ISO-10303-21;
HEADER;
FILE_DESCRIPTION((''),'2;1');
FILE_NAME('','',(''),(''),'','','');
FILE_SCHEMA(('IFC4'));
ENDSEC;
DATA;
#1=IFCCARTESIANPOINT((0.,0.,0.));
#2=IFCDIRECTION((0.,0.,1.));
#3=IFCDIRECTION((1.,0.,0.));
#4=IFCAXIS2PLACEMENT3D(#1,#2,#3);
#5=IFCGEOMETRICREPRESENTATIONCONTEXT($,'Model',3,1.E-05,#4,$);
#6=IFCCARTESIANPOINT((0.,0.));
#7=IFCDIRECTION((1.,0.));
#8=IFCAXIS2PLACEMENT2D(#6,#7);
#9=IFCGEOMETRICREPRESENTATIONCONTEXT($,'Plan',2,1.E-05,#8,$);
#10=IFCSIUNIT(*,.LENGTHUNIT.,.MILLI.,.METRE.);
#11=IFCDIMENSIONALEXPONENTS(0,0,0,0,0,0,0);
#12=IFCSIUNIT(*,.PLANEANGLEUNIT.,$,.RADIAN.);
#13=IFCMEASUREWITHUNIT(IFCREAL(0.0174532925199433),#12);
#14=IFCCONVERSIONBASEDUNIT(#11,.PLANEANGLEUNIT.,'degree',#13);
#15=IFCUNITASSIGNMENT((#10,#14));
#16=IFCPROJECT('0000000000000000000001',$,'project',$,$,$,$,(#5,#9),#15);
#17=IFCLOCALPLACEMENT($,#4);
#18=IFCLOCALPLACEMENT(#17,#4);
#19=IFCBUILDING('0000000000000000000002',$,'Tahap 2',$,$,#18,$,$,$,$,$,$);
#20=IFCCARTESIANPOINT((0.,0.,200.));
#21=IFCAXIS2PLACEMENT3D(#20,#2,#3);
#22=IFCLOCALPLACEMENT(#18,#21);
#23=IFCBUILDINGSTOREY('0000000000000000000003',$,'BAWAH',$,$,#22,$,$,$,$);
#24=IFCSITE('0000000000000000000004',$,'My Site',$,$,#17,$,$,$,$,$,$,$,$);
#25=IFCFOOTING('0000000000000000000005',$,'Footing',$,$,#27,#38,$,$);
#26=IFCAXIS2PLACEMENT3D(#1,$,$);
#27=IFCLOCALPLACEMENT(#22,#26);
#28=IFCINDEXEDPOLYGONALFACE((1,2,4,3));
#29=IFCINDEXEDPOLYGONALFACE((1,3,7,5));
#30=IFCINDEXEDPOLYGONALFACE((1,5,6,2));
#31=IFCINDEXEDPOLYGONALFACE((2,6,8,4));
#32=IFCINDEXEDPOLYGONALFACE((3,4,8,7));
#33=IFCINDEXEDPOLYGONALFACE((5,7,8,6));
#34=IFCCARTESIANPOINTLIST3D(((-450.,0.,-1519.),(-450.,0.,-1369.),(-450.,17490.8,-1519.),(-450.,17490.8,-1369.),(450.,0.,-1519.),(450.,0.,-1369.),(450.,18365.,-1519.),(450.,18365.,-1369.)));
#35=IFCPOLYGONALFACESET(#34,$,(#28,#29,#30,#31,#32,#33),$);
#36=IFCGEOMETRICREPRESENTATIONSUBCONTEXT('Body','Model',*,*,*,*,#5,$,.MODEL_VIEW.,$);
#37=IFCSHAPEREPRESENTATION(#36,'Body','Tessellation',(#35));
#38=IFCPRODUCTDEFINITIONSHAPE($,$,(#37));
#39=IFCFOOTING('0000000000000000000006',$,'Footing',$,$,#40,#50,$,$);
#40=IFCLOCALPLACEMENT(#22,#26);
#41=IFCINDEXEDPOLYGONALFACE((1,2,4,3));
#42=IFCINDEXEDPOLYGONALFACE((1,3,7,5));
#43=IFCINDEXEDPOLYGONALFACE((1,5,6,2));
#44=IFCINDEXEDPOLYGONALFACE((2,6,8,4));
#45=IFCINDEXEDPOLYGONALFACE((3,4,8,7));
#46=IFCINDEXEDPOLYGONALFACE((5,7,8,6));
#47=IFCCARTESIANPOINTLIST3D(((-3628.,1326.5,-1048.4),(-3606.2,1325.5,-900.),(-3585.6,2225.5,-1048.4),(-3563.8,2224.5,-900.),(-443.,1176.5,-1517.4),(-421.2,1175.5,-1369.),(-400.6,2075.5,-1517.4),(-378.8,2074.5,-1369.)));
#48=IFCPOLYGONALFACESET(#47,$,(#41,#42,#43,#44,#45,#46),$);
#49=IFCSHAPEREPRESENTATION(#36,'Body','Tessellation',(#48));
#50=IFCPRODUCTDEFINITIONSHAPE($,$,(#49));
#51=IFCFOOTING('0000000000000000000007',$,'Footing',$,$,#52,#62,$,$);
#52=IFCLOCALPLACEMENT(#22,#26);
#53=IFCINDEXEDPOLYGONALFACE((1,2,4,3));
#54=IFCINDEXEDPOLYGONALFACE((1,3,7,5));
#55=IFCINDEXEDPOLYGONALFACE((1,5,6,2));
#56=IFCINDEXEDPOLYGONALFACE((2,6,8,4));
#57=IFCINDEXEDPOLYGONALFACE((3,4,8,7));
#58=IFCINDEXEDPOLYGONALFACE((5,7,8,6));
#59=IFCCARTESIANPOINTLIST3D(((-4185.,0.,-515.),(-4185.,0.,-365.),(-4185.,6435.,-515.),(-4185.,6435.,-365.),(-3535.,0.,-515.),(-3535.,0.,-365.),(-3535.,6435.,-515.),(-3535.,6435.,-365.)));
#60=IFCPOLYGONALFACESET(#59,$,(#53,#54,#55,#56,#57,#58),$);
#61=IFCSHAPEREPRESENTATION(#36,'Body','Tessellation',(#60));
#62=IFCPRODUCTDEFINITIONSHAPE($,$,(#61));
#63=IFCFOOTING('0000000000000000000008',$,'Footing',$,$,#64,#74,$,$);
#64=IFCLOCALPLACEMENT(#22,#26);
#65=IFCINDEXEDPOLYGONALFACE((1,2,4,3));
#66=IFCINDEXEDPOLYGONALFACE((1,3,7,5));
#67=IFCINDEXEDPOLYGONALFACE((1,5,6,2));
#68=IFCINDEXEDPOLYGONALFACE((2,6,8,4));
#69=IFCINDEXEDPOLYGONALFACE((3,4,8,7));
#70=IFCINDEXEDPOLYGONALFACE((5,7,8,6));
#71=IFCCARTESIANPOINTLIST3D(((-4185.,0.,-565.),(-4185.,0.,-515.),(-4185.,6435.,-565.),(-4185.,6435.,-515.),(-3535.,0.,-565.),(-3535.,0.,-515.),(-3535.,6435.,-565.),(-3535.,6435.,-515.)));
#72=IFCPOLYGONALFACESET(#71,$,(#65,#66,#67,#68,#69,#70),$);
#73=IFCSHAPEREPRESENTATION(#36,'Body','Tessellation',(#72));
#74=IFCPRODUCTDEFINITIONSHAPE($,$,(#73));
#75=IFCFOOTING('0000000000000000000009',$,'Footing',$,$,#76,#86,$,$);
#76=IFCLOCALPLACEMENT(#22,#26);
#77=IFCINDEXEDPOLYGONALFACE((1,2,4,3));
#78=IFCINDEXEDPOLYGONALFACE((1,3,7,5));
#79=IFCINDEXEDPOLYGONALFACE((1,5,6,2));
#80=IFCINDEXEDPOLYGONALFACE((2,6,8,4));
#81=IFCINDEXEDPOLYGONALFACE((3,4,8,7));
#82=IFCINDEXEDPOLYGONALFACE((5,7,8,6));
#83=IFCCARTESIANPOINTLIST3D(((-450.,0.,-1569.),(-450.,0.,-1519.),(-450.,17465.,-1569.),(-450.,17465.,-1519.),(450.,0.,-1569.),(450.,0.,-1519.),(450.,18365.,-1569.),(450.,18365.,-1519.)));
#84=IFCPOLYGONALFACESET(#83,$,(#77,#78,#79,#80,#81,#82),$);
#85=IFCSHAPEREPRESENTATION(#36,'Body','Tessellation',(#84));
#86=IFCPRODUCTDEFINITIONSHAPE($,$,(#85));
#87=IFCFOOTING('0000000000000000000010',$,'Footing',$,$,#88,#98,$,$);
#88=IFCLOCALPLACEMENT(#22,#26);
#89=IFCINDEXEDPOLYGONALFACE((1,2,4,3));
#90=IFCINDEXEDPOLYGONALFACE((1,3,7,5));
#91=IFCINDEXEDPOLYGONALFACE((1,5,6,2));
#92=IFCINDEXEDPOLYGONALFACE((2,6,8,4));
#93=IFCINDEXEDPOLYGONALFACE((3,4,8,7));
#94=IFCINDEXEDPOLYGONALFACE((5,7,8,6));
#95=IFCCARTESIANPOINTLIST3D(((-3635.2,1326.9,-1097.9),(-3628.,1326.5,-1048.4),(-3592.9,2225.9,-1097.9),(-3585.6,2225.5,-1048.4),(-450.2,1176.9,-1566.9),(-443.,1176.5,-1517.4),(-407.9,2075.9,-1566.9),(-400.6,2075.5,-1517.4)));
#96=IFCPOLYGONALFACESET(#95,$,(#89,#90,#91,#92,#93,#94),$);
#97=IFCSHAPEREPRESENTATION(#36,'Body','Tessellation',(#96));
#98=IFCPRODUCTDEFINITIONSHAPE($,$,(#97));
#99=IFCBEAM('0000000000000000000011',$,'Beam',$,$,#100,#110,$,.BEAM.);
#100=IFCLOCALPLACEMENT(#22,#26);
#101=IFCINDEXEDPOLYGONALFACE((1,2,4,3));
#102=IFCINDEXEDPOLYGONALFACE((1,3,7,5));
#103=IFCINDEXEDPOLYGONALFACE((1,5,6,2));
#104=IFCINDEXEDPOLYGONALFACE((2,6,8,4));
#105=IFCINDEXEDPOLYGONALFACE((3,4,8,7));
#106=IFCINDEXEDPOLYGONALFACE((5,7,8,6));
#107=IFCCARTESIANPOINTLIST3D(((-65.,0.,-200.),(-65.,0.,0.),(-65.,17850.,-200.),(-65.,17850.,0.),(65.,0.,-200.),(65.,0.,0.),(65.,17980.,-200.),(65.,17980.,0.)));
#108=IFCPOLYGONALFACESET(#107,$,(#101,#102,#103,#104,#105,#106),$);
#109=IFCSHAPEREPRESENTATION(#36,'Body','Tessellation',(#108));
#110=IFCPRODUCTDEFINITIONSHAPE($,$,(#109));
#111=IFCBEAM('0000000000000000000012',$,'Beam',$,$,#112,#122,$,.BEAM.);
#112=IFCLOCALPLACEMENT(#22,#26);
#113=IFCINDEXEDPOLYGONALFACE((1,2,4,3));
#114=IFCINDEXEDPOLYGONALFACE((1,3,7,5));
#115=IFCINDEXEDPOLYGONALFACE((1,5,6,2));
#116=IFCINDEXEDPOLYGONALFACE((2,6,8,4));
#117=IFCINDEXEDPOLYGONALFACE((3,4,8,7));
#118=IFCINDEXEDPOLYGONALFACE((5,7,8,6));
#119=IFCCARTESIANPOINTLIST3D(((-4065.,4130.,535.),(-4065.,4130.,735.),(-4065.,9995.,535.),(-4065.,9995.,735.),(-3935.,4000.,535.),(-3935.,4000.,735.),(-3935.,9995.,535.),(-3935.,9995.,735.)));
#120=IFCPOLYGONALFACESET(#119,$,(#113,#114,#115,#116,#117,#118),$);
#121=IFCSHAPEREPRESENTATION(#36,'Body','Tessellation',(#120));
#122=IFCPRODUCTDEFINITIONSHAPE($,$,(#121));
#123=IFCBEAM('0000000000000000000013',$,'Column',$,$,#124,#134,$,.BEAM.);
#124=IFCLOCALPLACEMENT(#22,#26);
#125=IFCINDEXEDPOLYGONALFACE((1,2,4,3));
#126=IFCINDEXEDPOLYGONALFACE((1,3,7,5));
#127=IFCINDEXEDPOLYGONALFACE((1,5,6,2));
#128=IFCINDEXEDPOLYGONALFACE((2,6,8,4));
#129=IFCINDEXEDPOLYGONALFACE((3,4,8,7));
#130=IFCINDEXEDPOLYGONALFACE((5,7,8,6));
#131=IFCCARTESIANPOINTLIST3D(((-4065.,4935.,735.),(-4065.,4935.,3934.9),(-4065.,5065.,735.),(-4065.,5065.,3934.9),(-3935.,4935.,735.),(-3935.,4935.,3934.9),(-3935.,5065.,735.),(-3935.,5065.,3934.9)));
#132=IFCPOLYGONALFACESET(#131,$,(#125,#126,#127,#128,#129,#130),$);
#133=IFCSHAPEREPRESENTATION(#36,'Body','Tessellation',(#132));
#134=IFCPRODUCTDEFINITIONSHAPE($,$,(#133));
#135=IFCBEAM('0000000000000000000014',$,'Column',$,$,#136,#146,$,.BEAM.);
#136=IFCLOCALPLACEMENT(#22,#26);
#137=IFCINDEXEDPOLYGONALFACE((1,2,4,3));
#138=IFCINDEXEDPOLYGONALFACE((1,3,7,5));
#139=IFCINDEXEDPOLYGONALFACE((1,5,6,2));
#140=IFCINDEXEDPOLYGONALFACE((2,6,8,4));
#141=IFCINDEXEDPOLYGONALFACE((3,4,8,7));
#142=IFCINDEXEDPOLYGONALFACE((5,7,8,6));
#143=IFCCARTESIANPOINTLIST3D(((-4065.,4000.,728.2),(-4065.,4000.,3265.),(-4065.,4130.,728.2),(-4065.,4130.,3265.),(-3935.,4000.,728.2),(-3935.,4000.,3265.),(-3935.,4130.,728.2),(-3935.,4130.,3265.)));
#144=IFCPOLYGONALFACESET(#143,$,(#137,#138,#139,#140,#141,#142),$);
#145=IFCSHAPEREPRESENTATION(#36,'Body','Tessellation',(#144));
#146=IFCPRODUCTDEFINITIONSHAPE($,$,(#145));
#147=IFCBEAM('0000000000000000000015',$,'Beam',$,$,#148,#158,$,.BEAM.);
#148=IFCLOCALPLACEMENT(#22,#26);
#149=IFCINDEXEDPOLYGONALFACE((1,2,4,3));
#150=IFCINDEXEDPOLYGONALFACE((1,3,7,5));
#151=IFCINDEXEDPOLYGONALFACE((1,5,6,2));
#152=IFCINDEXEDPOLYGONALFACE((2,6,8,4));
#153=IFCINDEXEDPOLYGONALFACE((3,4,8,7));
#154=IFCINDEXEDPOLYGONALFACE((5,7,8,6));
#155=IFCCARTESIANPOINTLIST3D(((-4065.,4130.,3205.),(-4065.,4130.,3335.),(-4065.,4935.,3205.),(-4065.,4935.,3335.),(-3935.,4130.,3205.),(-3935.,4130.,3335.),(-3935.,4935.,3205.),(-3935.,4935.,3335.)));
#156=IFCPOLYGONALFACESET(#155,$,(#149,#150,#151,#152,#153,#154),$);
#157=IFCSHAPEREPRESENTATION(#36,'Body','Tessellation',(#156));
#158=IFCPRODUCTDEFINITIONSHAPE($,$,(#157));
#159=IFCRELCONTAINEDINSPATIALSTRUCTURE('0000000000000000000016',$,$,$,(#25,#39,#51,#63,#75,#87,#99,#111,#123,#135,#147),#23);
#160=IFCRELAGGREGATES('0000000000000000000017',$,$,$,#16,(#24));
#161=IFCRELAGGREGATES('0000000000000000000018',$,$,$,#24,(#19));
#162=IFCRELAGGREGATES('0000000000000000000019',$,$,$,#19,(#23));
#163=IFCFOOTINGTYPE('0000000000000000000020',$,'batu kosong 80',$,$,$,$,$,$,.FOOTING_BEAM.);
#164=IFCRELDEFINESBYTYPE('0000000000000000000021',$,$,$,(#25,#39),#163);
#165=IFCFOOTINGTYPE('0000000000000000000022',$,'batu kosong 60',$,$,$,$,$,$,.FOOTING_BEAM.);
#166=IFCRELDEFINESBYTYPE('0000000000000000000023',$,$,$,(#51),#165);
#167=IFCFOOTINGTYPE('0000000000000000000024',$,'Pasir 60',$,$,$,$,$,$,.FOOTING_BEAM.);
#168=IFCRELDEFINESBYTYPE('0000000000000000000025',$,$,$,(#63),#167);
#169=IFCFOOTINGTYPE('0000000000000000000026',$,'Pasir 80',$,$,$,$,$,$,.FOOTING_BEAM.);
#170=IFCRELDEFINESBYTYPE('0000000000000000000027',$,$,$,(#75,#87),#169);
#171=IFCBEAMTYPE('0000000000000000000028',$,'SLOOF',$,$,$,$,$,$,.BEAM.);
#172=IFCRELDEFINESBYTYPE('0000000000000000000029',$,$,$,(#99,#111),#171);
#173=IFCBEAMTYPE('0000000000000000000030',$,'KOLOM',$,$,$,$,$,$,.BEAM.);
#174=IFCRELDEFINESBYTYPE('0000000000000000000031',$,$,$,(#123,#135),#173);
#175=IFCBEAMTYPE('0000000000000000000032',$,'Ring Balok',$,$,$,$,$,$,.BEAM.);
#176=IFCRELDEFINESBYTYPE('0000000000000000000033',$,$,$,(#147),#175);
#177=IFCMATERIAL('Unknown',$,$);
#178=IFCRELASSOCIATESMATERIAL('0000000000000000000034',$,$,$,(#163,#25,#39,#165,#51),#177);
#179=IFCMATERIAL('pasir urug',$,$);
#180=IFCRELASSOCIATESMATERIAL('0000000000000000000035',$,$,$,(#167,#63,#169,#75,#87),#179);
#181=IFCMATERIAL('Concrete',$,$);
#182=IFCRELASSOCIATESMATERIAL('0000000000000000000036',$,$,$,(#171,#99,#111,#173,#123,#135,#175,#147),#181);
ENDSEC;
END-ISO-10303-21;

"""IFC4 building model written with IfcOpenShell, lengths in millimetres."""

from ifc_helpers import new_model, entity, si_unit, converted_unit, frame, origin_with_axes, origin_2d_with_axis, place, context, subcontext, project, spatial, indexed_curve, rectangle, outline, extrude, clip, halfspace, material, material_profile, profile_set, profile_usage, type_object, element, save


model = new_model("IFC4")

# Units and contexts
model_context = context("Model", 3, precision=1e-05, world=origin_with_axes())
plan_context = context("Plan", 2, precision=1e-05, world=origin_2d_with_axis())
body_context = subcontext(model_context, "Body", "Model", "MODEL_VIEW")
ifc_project = project(units=[si_unit("LENGTHUNIT", "METRE", prefix="MILLI"), converted_unit("PLANEANGLEUNIT", "degree", entity("IfcReal", 0.0174532925199433), si_unit("PLANEANGLEUNIT", "RADIAN"), dimensions=[0, 0, 0, 0, 0, 0, 0])], contexts=[model_context, plan_context])

# Site, building, storey
site_placement = place(None, origin_with_axes())
site = spatial("IfcSite", under=ifc_project, at=site_placement, Name="My Site")
building_placement = place(site_placement, origin_with_axes())
building = spatial("IfcBuilding", under=site, at=building_placement, Name="Tahap 2")
storey_placement = place(building_placement, frame((0.0, 0.0, 200.0), z_axis=(0.0, 0.0, 1.0), x_axis=(1.0, 0.0, 0.0)))
storey = spatial("IfcBuildingStorey", under=building, at=storey_placement, Name="BAWAH")

# Footings
ifc_material_1 = material(Name="Unknown")
ifc_material_profile_1 = material_profile(ifc_material_1, rectangle(XDim=900.0, YDim=150.0, kind="CURVE"))
ifc_profile_set_1 = profile_set([ifc_material_profile_1])
ifc_profile_usage_1 = profile_usage(ifc_profile_set_1, cardinal=8)
footing_type_1 = type_object("IfcFootingType", Name="batu kosong 80", PredefinedType="FOOTING_BEAM", material=ifc_profile_set_1)
footing_1_placement = place(storey_placement, frame((0.0, 0.0, -1369.0), z_axis=(0.0, 1.0, 0.0), x_axis=(-1.0, 0.0, 0.0)))
element("IfcFooting", 1, at=footing_1_placement, inside=storey, type_object=footing_type_1, material=ifc_profile_usage_1, Name="Footing", context=body_context, shape_type="Clipping", body=[
    clip(extrude(rectangle(XDim=900.0, YDim=150.0, kind="CURVE"), frame((0.0, -75.0, 0.0), z_axis=(0.0, 0.0, 1.0), x_axis=(1.0, 0.0, 0.0)), (0.0, 0.0, 1.0), 18365.0), halfspace(frame((-450.0, 1169.0, 18365.0), z_axis=(0.696756, 0.0, 0.717309), x_axis=(0.0, -1.0, 0.0)), False)),
])
ifc_profile_usage_2 = profile_usage(ifc_profile_set_1, cardinal=8)
footing_2_placement = place(storey_placement, frame((-400.0, 1625.0, -1369.0), z_axis=(-0.988259, 0.046543, 0.145524), x_axis=(-0.047044, -0.998893, 0.0)))
element("IfcFooting", 2, at=footing_2_placement, inside=storey, type_object=footing_type_1, material=ifc_profile_usage_2, Name="Footing", context=body_context, shape_type="SweptSolid", body=[
    extrude(rectangle(XDim=900.0, YDim=150.0, kind="CURVE"), frame((0.0, -75.0, 0.0), z_axis=(0.0, 0.0, 1.0), x_axis=(1.0, 0.0, 0.0)), (0.0, 0.0, 1.0), 3222.8),
])
ifc_material_profile_2 = material_profile(ifc_material_1, rectangle(XDim=650.0, YDim=150.0, kind="CURVE"))
ifc_profile_set_2 = profile_set([ifc_material_profile_2])
ifc_profile_usage_3 = profile_usage(ifc_profile_set_2, cardinal=9)
footing_type_2 = type_object("IfcFootingType", Name="batu kosong 60", PredefinedType="FOOTING_BEAM", material=ifc_profile_set_2)
footing_3_placement = place(storey_placement, frame((-3535.0, 0.0, -365.0), z_axis=(0.000001, 1.0, 0.0), x_axis=(-1.0, 0.000001, 0.0)))
element("IfcFooting", 3, at=footing_3_placement, inside=storey, type_object=footing_type_2, material=ifc_profile_usage_3, Name="Footing", context=body_context, shape_type="SweptSolid", body=[
    extrude(rectangle(XDim=650.0, YDim=150.0, kind="CURVE"), frame((325.0, -75.0, 0.0), z_axis=(0.0, 0.0, 1.0), x_axis=(1.0, 0.0, 0.0)), (0.0, 0.0, 1.0), 6435.0),
])
ifc_material_2 = material(Name="pasir urug")
ifc_material_profile_3 = material_profile(ifc_material_2, rectangle(XDim=650.0, YDim=50.0, kind="CURVE"))
ifc_profile_set_3 = profile_set([ifc_material_profile_3])
ifc_profile_usage_4 = profile_usage(ifc_profile_set_3, cardinal=8)
footing_type_3 = type_object("IfcFootingType", Name="Pasir 60", PredefinedType="FOOTING_BEAM", material=ifc_profile_set_3)
footing_4_placement = place(storey_placement, frame((-3860.0, 0.0, -515.0), z_axis=(0.000001, 1.0, 0.0), x_axis=(-1.0, 0.000001, 0.0)))
element("IfcFooting", 4, at=footing_4_placement, inside=storey, type_object=footing_type_3, material=ifc_profile_usage_4, Name="Footing", context=body_context, shape_type="SweptSolid", body=[
    extrude(rectangle(XDim=650.0, YDim=50.0, kind="CURVE"), frame((0.0, -25.0, 0.0), z_axis=(0.0, 0.0, 1.0), x_axis=(1.0, 0.0, 0.0)), (0.0, 0.0, 1.0), 6435.0),
])
ifc_material_profile_4 = material_profile(ifc_material_2, rectangle(XDim=900.0, YDim=50.0, kind="CURVE"))
ifc_profile_set_4 = profile_set([ifc_material_profile_4])
ifc_profile_usage_5 = profile_usage(ifc_profile_set_4, cardinal=9)
footing_type_4 = type_object("IfcFootingType", Name="Pasir 80", PredefinedType="FOOTING_BEAM", material=ifc_profile_set_4)
footing_5_placement = place(storey_placement, frame((450.0, 0.0, -1519.0), z_axis=(0.0, 1.0, 0.0), x_axis=(-1.0, 0.0, 0.0)))
element("IfcFooting", 5, at=footing_5_placement, inside=storey, type_object=footing_type_4, material=ifc_profile_usage_5, Name="Footing", context=body_context, shape_type="Clipping", body=[
    clip(extrude(rectangle(XDim=900.0, YDim=50.0, kind="CURVE"), frame((450.0, -25.0, 0.0), z_axis=(0.0, 0.0, 1.0), x_axis=(1.0, 0.0, 0.0)), (0.0, 0.0, 1.0), 18365.0), halfspace(frame((0.0, 1319.0, 18365.0), z_axis=(0.707107, 0.0, 0.707107), x_axis=(0.0, -1.0, 0.0)), False)),
])
ifc_profile_usage_6 = profile_usage(ifc_profile_set_4, cardinal=9)
footing_6_placement = place(storey_placement, frame((-400.6, 2075.5, -1517.4), z_axis=(-0.988259, 0.046543, 0.145524), x_axis=(-0.047044, -0.998893, 0.0)))
element("IfcFooting", 6, at=footing_6_placement, inside=storey, type_object=footing_type_4, material=ifc_profile_usage_6, Name="Footing", context=body_context, shape_type="SweptSolid", body=[
    extrude(rectangle(XDim=900.0, YDim=50.0, kind="CURVE"), frame((450.0, -25.0, 0.0), z_axis=(0.0, 0.0, 1.0), x_axis=(1.0, 0.0, 0.0)), (0.0, 0.0, 1.0), 3222.8),
])

# Beams
ifc_material_3 = material(Name="Concrete")
ifc_material_profile_5 = material_profile(ifc_material_3, outline(indexed_curve([(-65.0, 100.0), (65.0, 100.0), (65.0, -100.0), (-65.0, -100.0), (-65.0, 100.0)])))
ifc_profile_set_5 = profile_set([ifc_material_profile_5])
ifc_profile_usage_7 = profile_usage(ifc_profile_set_5, cardinal=2)
beam_type_1 = type_object("IfcBeamType", Name="SLOOF", PredefinedType="BEAM", material=ifc_profile_set_5)
beam_1_placement = place(storey_placement, frame((0.0, 0.0, -200.0), z_axis=(0.0, 1.0, 0.0), x_axis=(-1.0, 0.0, 0.0)))
element("IfcBeam", 7, at=beam_1_placement, inside=storey, type_object=beam_type_1, material=ifc_profile_usage_7, Name="Beam", PredefinedType="BEAM", context=body_context, shape_type="Clipping", body=[
    clip(extrude(outline(indexed_curve([(-65.0, 100.0), (65.0, 100.0), (65.0, -100.0), (-65.0, -100.0), (-65.0, 100.0)])), frame((0.0, 100.0, 0.0), z_axis=(0.0, 0.0, 1.0), x_axis=(1.0, 0.0, 0.0)), (0.0, 0.0, 1.0), 17980.0), halfspace(frame((-65.0, 0.0, 17980.0), z_axis=(0.70711, 0.0, 0.707104), x_axis=(0.0, -1.0, 0.0)), False)),
])
ifc_profile_usage_8 = profile_usage(ifc_profile_set_5, cardinal=3)
beam_2_placement = place(storey_placement, frame((-3935.0, 4000.0, 535.0), z_axis=(0.0, 1.0, 0.0), x_axis=(-1.0, 0.0, 0.0)))
element("IfcBeam", 8, at=beam_2_placement, inside=storey, type_object=beam_type_1, material=ifc_profile_usage_8, Name="Beam", PredefinedType="BEAM", context=body_context, shape_type="Clipping", body=[
    clip(extrude(outline(indexed_curve([(-65.0, 100.0), (65.0, 100.0), (65.0, -100.0), (-65.0, -100.0), (-65.0, 100.0)])), frame((65.0, 100.0, 0.0), z_axis=(0.0, 0.0, 1.0), x_axis=(1.0, 0.0, 0.0)), (0.0, 0.0, 1.0), 5995.0), halfspace(frame((0.0, -735.0, 0.0), z_axis=(0.707106, 0.0, -0.707107), x_axis=(-0.000001, -1.0, 0.0)), False)),
])
ifc_material_profile_6 = material_profile(ifc_material_3, rectangle(XDim=130.0, YDim=130.0, kind="CURVE"))
ifc_profile_set_6 = profile_set([ifc_material_profile_6])
ifc_profile_usage_9 = profile_usage(ifc_profile_set_6, cardinal=5)
beam_type_2 = type_object("IfcBeamType", Name="KOLOM", PredefinedType="BEAM", material=ifc_profile_set_6)
beam_3_placement = place(storey_placement, frame((-4000.0, 5000.0, 735.0), z_axis=(0.0, 0.0, 1.0), x_axis=(1.0, 0.0, 0.0)))
element("IfcBeam", 9, at=beam_3_placement, inside=storey, type_object=beam_type_2, material=ifc_profile_usage_9, Name="Column", PredefinedType="BEAM", context=body_context, shape_type="SweptSolid", body=[
    extrude(rectangle(XDim=130.0, YDim=130.0, kind="CURVE"), origin_with_axes(), (0.0, 0.0, 1.0), 3199.9),
])
ifc_profile_usage_10 = profile_usage(ifc_profile_set_6, cardinal=5)
beam_4_placement = place(storey_placement, frame((-4000.0, 4065.0, 728.2), z_axis=(0.0, 0.0, 1.0), x_axis=(1.0, 0.0, 0.0)))
element("IfcBeam", 10, at=beam_4_placement, inside=storey, type_object=beam_type_2, material=ifc_profile_usage_10, Name="Column", PredefinedType="BEAM", context=body_context, shape_type="SweptSolid", body=[
    extrude(rectangle(XDim=130.0, YDim=130.0, kind="CURVE"), origin_with_axes(), (0.0, 0.0, 1.0), 2536.8),
])
ifc_material_profile_7 = material_profile(ifc_material_3, rectangle(XDim=130.0, YDim=130.0))
ifc_profile_set_7 = profile_set([ifc_material_profile_7])
ifc_profile_usage_11 = profile_usage(ifc_profile_set_7)
beam_type_3 = type_object("IfcBeamType", Name="Ring Balok", PredefinedType="BEAM", material=ifc_profile_set_7)
beam_5_placement = place(storey_placement, frame((-4000.0, 4130.0, 3270.0), z_axis=(0.0, 1.0, 0.0), x_axis=(-1.0, 0.0, 0.0)))
element("IfcBeam", 11, at=beam_5_placement, inside=storey, type_object=beam_type_3, material=ifc_profile_usage_11, Name="Beam", PredefinedType="BEAM", context=body_context, shape_type="SweptSolid", body=[
    extrude(rectangle(XDim=130.0, YDim=130.0), origin_with_axes(), (0.0, 0.0, 1.0), 805.0),
])

save(model, "model.ifc")
